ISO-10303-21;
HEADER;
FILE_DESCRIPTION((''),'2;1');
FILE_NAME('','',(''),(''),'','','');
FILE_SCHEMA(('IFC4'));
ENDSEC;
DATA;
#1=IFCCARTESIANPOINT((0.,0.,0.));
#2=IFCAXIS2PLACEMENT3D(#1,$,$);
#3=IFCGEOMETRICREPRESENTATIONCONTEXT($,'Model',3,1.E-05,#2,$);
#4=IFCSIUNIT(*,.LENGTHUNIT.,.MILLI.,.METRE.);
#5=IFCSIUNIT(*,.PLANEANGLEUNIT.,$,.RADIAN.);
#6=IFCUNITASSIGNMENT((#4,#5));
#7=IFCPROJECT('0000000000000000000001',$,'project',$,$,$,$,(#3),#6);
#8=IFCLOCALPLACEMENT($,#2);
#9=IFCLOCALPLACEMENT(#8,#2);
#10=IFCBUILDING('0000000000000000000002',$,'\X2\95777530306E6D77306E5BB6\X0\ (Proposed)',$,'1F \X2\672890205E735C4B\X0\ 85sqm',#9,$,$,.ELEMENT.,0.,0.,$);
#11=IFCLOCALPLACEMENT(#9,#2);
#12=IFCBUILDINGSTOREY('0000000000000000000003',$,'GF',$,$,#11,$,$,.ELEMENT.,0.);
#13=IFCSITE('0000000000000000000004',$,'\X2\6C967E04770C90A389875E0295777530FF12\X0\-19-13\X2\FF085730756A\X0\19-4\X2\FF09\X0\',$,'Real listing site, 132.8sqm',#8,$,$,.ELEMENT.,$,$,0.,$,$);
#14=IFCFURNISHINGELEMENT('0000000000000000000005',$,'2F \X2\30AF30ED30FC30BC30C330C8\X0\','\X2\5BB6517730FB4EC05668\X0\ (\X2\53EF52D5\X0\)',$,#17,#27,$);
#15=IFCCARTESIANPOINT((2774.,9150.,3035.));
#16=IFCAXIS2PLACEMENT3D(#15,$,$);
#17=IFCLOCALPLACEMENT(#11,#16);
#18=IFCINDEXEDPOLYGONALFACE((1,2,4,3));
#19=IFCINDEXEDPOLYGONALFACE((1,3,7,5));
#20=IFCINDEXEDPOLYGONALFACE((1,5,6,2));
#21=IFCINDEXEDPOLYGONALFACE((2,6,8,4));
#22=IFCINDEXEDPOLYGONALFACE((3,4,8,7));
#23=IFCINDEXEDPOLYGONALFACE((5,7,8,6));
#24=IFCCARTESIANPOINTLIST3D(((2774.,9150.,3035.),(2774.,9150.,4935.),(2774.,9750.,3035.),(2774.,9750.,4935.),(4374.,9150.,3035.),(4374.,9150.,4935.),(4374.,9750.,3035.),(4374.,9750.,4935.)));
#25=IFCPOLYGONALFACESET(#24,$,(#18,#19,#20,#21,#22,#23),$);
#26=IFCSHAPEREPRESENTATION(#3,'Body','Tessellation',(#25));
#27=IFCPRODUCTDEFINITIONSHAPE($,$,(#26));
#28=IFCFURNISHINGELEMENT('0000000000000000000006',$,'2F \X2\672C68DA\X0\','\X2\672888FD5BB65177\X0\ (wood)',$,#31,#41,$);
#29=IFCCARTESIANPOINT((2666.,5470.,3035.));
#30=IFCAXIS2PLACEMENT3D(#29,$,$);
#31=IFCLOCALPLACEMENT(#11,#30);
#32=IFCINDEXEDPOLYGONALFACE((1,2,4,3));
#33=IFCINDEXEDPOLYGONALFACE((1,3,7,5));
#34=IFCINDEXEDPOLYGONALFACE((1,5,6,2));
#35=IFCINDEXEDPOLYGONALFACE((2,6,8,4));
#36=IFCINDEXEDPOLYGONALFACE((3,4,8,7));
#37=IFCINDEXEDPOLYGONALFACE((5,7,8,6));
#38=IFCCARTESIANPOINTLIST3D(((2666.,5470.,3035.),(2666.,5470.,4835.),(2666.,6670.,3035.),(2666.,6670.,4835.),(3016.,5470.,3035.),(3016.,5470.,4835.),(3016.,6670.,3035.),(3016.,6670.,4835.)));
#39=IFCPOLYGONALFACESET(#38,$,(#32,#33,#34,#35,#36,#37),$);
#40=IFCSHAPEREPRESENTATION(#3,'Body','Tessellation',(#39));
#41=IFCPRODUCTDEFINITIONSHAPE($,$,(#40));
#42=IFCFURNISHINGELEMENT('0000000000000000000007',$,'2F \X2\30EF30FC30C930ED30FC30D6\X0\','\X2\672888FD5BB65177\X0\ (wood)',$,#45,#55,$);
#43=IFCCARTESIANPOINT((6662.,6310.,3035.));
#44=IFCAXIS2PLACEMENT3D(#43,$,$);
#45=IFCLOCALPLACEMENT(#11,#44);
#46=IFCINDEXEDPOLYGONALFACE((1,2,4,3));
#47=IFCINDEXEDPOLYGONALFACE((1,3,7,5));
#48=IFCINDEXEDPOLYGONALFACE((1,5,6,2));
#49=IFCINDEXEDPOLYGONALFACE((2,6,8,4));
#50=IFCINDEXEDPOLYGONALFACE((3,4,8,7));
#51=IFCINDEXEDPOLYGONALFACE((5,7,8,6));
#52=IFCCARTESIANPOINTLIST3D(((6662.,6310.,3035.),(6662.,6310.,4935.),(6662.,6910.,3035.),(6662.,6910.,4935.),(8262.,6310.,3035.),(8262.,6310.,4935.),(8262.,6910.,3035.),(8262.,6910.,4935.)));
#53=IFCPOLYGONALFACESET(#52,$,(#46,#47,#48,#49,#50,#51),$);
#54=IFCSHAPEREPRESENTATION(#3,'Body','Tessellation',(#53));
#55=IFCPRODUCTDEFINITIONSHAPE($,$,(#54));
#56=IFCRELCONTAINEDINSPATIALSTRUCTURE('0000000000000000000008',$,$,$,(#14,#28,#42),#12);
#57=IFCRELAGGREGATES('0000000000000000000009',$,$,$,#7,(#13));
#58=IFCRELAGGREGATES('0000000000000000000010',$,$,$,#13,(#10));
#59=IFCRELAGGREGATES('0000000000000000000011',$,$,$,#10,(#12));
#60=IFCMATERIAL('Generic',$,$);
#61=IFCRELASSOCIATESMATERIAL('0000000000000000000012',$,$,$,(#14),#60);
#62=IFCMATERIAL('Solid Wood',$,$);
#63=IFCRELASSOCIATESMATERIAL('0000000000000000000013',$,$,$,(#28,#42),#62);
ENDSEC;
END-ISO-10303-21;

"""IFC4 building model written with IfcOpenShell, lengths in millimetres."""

from ifc_helpers import new_model, si_unit, frame, frame_2d, origin, place, context, project, spatial, rectangle, extrude, material, element, save


model = new_model("IFC4")

# Units and contexts
model_context = context("Model", 3, precision=1e-05, world=origin())
ifc_project = project(units=[si_unit("LENGTHUNIT", "METRE", prefix="MILLI"), si_unit("PLANEANGLEUNIT", "RADIAN")], contexts=[model_context])

# Site, building, storey
site_placement = place(None, origin())
site = spatial("IfcSite", under=ifc_project, at=site_placement, Name="沖縄県那覇市長田２-19-13（地番19-4）", ObjectType="Real listing site, 132.8sqm", CompositionType="ELEMENT", RefElevation=0.0)
building_placement = place(site_placement, origin())
building = spatial("IfcBuilding", under=site, at=building_placement, Name="長田の海の家 (Proposed)", ObjectType="1F 木造平屋 85sqm", CompositionType="ELEMENT", ElevationOfRefHeight=0.0, ElevationOfTerrain=0.0)
storey_placement = place(building_placement, origin())
storey = spatial("IfcBuildingStorey", under=building, at=storey_placement, Name="GF", CompositionType="ELEMENT", Elevation=0.0)

# Shared definitions
ifc_material_1 = material(Name="Solid Wood")

# Shared definitions
ifc_material_2 = material(Name="Generic")

# Furnishing elements
furnishing_1_placement = place(storey_placement, frame((2774.0, 9150.0, 3035.0)))
element("IfcFurnishingElement", 1, at=furnishing_1_placement, inside=storey, material=ifc_material_2, Name="2F クローゼット", Description="家具・什器 (可動)", context=model_context, shape_type="SweptSolid", body=[
    extrude(rectangle(XDim=1600.0, YDim=600.0, at=frame_2d((800.0, 300.0))), frame((2774.0, 9150.0, 3035.0)), (0.0, 0.0, 1.0), 1900.0),
])
furnishing_2_placement = place(storey_placement, frame((2666.0, 5470.0, 3035.0)))
element("IfcFurnishingElement", 2, at=furnishing_2_placement, inside=storey, material=ifc_material_1, Name="2F 本棚", Description="木製家具 (wood)", context=model_context, shape_type="SweptSolid", body=[
    extrude(rectangle(XDim=350.0, YDim=1200.0, at=frame_2d((175.0, 600.0))), frame((2666.0, 5470.0, 3035.0)), (0.0, 0.0, 1.0), 1800.0),
])
furnishing_3_placement = place(storey_placement, frame((6662.0, 6310.0, 3035.0)))
element("IfcFurnishingElement", 3, at=furnishing_3_placement, inside=storey, material=ifc_material_1, Name="2F ワードローブ", Description="木製家具 (wood)", context=model_context, shape_type="SweptSolid", body=[
    extrude(rectangle(XDim=1600.0, YDim=600.0, at=frame_2d((800.0, 300.0))), frame((6662.0, 6310.0, 3035.0)), (0.0, 0.0, 1.0), 1900.0),
])

save(model, "model.ifc")
